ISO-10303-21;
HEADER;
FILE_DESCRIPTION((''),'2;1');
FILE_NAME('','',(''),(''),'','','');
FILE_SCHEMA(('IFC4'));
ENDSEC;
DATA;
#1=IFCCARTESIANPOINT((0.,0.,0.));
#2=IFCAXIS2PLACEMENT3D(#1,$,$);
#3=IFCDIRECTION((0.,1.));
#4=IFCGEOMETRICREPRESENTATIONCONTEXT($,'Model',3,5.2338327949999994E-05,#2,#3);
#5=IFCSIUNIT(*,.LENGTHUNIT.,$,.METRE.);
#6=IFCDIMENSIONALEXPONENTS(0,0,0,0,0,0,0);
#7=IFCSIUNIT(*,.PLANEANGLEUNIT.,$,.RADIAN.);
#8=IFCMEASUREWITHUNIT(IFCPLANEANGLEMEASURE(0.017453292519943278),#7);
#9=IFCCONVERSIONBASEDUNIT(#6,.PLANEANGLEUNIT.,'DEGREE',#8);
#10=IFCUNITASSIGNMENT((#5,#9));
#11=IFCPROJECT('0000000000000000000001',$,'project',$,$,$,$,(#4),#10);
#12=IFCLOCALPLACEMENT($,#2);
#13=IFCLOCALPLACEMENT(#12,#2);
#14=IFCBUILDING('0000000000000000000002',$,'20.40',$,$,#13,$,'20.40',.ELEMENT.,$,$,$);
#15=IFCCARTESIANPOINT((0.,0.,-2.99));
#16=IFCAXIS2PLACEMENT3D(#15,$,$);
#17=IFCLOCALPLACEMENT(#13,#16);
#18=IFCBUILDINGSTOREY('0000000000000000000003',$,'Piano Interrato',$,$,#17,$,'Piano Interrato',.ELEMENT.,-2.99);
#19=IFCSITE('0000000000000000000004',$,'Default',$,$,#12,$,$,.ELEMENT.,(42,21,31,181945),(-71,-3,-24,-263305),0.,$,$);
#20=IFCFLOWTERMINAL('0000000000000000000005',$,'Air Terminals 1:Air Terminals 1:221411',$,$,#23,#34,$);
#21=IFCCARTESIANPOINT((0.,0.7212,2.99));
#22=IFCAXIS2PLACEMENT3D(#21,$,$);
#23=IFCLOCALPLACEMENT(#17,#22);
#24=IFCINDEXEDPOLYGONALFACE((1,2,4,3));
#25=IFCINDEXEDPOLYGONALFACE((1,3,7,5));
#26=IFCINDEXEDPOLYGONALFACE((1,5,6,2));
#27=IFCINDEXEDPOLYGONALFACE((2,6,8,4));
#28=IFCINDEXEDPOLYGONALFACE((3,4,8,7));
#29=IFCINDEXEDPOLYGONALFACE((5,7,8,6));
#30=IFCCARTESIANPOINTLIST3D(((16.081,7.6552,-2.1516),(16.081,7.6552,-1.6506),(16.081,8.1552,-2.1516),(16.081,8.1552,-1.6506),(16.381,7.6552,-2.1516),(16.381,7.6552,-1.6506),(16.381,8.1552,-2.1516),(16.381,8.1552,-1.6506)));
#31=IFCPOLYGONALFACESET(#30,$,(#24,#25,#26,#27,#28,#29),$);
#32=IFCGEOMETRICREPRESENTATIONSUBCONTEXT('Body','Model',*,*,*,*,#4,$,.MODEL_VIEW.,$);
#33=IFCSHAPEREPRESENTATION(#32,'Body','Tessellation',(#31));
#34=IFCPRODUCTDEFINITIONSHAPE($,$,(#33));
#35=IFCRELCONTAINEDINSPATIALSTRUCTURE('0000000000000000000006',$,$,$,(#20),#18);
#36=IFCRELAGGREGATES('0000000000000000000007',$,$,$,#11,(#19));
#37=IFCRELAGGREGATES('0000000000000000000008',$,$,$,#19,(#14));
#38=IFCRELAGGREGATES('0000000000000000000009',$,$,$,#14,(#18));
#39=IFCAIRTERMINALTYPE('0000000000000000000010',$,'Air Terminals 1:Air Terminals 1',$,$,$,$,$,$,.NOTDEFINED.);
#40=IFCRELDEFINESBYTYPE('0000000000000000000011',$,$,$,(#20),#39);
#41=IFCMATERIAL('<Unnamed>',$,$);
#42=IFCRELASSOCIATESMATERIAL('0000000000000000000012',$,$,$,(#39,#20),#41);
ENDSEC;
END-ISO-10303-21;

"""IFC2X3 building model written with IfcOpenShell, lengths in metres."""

from ifc_helpers import new_model, entity, si_unit, converted_unit, direction, frame, frame_2d, origin, place, context, subcontext, project, spatial, rectangle, extrude, source, transform, mapped, material, type_object, type_shapes, element, save


model = new_model("IFC2X3")

# Units and contexts
model_context = context("Model", 3, precision=5.2338327949999994e-05, world=origin(), true_north=direction((0.0, 1.0)))
body_context = subcontext(model_context, "Body", "Model", "MODEL_VIEW")
ifc_project = project(units=[si_unit("LENGTHUNIT", "METRE"), converted_unit("PLANEANGLEUNIT", "DEGREE", entity("IfcPlaneAngleMeasure", 0.017453292519943278), si_unit("PLANEANGLEUNIT", "RADIAN"), dimensions=[0, 0, 0, 0, 0, 0, 0])], contexts=[model_context])

# Site, building, storey
site_placement = place(None, origin())
site = spatial("IfcSite", under=ifc_project, at=site_placement, Name="Default", CompositionType="ELEMENT", RefLatitude=(42, 21, 31, 181945), RefLongitude=(-71, -3, -24, -263305), RefElevation=0.0)
building_placement = place(site_placement, origin())
building = spatial("IfcBuilding", under=site, at=building_placement, Name="20.40", LongName="20.40", CompositionType="ELEMENT")
storey_placement = place(building_placement, frame((0.0, 0.0, -2.99)))
storey = spatial("IfcBuildingStorey", under=building, at=storey_placement, Name="Piano Interrato", LongName="Piano Interrato", CompositionType="ELEMENT", Elevation=-2.99)

# Flow terminal
ifc_material = material(Name="<Unnamed>")
air_terminal_type = type_object("IfcAirTerminalType", Name="Air Terminals 1:Air Terminals 1", PredefinedType="NOTDEFINED", material=ifc_material)
shared_shape = source(origin(), body_context, "Body", "SweptSolid", [
    extrude(rectangle(XDim=0.3, YDim=0.5, at=frame_2d((0.0, 0.0), x_axis=(1.0, 0.0))), frame((16.231, 7.9052, -2.1516), z_axis=(0.0, 0.0, 1.0), x_axis=(-1.0, 0.0, 0.0)), (0.0, 0.0, 1.0), 0.501),
])
type_shapes(air_terminal_type, [shared_shape])
flow_terminal_placement = place(storey_placement, frame((0.0, 0.7212, 2.99)))
element("IfcFlowTerminal", 1, at=flow_terminal_placement, inside=storey, type_object=air_terminal_type, material=ifc_material, Name="Air Terminals 1:Air Terminals 1:221411", context=body_context, shape_type="MappedRepresentation", body=[
    mapped(shared_shape, transform((0.0, 0.0, 0.0), scale=1.0)),
])

save(model, "model.ifc")
